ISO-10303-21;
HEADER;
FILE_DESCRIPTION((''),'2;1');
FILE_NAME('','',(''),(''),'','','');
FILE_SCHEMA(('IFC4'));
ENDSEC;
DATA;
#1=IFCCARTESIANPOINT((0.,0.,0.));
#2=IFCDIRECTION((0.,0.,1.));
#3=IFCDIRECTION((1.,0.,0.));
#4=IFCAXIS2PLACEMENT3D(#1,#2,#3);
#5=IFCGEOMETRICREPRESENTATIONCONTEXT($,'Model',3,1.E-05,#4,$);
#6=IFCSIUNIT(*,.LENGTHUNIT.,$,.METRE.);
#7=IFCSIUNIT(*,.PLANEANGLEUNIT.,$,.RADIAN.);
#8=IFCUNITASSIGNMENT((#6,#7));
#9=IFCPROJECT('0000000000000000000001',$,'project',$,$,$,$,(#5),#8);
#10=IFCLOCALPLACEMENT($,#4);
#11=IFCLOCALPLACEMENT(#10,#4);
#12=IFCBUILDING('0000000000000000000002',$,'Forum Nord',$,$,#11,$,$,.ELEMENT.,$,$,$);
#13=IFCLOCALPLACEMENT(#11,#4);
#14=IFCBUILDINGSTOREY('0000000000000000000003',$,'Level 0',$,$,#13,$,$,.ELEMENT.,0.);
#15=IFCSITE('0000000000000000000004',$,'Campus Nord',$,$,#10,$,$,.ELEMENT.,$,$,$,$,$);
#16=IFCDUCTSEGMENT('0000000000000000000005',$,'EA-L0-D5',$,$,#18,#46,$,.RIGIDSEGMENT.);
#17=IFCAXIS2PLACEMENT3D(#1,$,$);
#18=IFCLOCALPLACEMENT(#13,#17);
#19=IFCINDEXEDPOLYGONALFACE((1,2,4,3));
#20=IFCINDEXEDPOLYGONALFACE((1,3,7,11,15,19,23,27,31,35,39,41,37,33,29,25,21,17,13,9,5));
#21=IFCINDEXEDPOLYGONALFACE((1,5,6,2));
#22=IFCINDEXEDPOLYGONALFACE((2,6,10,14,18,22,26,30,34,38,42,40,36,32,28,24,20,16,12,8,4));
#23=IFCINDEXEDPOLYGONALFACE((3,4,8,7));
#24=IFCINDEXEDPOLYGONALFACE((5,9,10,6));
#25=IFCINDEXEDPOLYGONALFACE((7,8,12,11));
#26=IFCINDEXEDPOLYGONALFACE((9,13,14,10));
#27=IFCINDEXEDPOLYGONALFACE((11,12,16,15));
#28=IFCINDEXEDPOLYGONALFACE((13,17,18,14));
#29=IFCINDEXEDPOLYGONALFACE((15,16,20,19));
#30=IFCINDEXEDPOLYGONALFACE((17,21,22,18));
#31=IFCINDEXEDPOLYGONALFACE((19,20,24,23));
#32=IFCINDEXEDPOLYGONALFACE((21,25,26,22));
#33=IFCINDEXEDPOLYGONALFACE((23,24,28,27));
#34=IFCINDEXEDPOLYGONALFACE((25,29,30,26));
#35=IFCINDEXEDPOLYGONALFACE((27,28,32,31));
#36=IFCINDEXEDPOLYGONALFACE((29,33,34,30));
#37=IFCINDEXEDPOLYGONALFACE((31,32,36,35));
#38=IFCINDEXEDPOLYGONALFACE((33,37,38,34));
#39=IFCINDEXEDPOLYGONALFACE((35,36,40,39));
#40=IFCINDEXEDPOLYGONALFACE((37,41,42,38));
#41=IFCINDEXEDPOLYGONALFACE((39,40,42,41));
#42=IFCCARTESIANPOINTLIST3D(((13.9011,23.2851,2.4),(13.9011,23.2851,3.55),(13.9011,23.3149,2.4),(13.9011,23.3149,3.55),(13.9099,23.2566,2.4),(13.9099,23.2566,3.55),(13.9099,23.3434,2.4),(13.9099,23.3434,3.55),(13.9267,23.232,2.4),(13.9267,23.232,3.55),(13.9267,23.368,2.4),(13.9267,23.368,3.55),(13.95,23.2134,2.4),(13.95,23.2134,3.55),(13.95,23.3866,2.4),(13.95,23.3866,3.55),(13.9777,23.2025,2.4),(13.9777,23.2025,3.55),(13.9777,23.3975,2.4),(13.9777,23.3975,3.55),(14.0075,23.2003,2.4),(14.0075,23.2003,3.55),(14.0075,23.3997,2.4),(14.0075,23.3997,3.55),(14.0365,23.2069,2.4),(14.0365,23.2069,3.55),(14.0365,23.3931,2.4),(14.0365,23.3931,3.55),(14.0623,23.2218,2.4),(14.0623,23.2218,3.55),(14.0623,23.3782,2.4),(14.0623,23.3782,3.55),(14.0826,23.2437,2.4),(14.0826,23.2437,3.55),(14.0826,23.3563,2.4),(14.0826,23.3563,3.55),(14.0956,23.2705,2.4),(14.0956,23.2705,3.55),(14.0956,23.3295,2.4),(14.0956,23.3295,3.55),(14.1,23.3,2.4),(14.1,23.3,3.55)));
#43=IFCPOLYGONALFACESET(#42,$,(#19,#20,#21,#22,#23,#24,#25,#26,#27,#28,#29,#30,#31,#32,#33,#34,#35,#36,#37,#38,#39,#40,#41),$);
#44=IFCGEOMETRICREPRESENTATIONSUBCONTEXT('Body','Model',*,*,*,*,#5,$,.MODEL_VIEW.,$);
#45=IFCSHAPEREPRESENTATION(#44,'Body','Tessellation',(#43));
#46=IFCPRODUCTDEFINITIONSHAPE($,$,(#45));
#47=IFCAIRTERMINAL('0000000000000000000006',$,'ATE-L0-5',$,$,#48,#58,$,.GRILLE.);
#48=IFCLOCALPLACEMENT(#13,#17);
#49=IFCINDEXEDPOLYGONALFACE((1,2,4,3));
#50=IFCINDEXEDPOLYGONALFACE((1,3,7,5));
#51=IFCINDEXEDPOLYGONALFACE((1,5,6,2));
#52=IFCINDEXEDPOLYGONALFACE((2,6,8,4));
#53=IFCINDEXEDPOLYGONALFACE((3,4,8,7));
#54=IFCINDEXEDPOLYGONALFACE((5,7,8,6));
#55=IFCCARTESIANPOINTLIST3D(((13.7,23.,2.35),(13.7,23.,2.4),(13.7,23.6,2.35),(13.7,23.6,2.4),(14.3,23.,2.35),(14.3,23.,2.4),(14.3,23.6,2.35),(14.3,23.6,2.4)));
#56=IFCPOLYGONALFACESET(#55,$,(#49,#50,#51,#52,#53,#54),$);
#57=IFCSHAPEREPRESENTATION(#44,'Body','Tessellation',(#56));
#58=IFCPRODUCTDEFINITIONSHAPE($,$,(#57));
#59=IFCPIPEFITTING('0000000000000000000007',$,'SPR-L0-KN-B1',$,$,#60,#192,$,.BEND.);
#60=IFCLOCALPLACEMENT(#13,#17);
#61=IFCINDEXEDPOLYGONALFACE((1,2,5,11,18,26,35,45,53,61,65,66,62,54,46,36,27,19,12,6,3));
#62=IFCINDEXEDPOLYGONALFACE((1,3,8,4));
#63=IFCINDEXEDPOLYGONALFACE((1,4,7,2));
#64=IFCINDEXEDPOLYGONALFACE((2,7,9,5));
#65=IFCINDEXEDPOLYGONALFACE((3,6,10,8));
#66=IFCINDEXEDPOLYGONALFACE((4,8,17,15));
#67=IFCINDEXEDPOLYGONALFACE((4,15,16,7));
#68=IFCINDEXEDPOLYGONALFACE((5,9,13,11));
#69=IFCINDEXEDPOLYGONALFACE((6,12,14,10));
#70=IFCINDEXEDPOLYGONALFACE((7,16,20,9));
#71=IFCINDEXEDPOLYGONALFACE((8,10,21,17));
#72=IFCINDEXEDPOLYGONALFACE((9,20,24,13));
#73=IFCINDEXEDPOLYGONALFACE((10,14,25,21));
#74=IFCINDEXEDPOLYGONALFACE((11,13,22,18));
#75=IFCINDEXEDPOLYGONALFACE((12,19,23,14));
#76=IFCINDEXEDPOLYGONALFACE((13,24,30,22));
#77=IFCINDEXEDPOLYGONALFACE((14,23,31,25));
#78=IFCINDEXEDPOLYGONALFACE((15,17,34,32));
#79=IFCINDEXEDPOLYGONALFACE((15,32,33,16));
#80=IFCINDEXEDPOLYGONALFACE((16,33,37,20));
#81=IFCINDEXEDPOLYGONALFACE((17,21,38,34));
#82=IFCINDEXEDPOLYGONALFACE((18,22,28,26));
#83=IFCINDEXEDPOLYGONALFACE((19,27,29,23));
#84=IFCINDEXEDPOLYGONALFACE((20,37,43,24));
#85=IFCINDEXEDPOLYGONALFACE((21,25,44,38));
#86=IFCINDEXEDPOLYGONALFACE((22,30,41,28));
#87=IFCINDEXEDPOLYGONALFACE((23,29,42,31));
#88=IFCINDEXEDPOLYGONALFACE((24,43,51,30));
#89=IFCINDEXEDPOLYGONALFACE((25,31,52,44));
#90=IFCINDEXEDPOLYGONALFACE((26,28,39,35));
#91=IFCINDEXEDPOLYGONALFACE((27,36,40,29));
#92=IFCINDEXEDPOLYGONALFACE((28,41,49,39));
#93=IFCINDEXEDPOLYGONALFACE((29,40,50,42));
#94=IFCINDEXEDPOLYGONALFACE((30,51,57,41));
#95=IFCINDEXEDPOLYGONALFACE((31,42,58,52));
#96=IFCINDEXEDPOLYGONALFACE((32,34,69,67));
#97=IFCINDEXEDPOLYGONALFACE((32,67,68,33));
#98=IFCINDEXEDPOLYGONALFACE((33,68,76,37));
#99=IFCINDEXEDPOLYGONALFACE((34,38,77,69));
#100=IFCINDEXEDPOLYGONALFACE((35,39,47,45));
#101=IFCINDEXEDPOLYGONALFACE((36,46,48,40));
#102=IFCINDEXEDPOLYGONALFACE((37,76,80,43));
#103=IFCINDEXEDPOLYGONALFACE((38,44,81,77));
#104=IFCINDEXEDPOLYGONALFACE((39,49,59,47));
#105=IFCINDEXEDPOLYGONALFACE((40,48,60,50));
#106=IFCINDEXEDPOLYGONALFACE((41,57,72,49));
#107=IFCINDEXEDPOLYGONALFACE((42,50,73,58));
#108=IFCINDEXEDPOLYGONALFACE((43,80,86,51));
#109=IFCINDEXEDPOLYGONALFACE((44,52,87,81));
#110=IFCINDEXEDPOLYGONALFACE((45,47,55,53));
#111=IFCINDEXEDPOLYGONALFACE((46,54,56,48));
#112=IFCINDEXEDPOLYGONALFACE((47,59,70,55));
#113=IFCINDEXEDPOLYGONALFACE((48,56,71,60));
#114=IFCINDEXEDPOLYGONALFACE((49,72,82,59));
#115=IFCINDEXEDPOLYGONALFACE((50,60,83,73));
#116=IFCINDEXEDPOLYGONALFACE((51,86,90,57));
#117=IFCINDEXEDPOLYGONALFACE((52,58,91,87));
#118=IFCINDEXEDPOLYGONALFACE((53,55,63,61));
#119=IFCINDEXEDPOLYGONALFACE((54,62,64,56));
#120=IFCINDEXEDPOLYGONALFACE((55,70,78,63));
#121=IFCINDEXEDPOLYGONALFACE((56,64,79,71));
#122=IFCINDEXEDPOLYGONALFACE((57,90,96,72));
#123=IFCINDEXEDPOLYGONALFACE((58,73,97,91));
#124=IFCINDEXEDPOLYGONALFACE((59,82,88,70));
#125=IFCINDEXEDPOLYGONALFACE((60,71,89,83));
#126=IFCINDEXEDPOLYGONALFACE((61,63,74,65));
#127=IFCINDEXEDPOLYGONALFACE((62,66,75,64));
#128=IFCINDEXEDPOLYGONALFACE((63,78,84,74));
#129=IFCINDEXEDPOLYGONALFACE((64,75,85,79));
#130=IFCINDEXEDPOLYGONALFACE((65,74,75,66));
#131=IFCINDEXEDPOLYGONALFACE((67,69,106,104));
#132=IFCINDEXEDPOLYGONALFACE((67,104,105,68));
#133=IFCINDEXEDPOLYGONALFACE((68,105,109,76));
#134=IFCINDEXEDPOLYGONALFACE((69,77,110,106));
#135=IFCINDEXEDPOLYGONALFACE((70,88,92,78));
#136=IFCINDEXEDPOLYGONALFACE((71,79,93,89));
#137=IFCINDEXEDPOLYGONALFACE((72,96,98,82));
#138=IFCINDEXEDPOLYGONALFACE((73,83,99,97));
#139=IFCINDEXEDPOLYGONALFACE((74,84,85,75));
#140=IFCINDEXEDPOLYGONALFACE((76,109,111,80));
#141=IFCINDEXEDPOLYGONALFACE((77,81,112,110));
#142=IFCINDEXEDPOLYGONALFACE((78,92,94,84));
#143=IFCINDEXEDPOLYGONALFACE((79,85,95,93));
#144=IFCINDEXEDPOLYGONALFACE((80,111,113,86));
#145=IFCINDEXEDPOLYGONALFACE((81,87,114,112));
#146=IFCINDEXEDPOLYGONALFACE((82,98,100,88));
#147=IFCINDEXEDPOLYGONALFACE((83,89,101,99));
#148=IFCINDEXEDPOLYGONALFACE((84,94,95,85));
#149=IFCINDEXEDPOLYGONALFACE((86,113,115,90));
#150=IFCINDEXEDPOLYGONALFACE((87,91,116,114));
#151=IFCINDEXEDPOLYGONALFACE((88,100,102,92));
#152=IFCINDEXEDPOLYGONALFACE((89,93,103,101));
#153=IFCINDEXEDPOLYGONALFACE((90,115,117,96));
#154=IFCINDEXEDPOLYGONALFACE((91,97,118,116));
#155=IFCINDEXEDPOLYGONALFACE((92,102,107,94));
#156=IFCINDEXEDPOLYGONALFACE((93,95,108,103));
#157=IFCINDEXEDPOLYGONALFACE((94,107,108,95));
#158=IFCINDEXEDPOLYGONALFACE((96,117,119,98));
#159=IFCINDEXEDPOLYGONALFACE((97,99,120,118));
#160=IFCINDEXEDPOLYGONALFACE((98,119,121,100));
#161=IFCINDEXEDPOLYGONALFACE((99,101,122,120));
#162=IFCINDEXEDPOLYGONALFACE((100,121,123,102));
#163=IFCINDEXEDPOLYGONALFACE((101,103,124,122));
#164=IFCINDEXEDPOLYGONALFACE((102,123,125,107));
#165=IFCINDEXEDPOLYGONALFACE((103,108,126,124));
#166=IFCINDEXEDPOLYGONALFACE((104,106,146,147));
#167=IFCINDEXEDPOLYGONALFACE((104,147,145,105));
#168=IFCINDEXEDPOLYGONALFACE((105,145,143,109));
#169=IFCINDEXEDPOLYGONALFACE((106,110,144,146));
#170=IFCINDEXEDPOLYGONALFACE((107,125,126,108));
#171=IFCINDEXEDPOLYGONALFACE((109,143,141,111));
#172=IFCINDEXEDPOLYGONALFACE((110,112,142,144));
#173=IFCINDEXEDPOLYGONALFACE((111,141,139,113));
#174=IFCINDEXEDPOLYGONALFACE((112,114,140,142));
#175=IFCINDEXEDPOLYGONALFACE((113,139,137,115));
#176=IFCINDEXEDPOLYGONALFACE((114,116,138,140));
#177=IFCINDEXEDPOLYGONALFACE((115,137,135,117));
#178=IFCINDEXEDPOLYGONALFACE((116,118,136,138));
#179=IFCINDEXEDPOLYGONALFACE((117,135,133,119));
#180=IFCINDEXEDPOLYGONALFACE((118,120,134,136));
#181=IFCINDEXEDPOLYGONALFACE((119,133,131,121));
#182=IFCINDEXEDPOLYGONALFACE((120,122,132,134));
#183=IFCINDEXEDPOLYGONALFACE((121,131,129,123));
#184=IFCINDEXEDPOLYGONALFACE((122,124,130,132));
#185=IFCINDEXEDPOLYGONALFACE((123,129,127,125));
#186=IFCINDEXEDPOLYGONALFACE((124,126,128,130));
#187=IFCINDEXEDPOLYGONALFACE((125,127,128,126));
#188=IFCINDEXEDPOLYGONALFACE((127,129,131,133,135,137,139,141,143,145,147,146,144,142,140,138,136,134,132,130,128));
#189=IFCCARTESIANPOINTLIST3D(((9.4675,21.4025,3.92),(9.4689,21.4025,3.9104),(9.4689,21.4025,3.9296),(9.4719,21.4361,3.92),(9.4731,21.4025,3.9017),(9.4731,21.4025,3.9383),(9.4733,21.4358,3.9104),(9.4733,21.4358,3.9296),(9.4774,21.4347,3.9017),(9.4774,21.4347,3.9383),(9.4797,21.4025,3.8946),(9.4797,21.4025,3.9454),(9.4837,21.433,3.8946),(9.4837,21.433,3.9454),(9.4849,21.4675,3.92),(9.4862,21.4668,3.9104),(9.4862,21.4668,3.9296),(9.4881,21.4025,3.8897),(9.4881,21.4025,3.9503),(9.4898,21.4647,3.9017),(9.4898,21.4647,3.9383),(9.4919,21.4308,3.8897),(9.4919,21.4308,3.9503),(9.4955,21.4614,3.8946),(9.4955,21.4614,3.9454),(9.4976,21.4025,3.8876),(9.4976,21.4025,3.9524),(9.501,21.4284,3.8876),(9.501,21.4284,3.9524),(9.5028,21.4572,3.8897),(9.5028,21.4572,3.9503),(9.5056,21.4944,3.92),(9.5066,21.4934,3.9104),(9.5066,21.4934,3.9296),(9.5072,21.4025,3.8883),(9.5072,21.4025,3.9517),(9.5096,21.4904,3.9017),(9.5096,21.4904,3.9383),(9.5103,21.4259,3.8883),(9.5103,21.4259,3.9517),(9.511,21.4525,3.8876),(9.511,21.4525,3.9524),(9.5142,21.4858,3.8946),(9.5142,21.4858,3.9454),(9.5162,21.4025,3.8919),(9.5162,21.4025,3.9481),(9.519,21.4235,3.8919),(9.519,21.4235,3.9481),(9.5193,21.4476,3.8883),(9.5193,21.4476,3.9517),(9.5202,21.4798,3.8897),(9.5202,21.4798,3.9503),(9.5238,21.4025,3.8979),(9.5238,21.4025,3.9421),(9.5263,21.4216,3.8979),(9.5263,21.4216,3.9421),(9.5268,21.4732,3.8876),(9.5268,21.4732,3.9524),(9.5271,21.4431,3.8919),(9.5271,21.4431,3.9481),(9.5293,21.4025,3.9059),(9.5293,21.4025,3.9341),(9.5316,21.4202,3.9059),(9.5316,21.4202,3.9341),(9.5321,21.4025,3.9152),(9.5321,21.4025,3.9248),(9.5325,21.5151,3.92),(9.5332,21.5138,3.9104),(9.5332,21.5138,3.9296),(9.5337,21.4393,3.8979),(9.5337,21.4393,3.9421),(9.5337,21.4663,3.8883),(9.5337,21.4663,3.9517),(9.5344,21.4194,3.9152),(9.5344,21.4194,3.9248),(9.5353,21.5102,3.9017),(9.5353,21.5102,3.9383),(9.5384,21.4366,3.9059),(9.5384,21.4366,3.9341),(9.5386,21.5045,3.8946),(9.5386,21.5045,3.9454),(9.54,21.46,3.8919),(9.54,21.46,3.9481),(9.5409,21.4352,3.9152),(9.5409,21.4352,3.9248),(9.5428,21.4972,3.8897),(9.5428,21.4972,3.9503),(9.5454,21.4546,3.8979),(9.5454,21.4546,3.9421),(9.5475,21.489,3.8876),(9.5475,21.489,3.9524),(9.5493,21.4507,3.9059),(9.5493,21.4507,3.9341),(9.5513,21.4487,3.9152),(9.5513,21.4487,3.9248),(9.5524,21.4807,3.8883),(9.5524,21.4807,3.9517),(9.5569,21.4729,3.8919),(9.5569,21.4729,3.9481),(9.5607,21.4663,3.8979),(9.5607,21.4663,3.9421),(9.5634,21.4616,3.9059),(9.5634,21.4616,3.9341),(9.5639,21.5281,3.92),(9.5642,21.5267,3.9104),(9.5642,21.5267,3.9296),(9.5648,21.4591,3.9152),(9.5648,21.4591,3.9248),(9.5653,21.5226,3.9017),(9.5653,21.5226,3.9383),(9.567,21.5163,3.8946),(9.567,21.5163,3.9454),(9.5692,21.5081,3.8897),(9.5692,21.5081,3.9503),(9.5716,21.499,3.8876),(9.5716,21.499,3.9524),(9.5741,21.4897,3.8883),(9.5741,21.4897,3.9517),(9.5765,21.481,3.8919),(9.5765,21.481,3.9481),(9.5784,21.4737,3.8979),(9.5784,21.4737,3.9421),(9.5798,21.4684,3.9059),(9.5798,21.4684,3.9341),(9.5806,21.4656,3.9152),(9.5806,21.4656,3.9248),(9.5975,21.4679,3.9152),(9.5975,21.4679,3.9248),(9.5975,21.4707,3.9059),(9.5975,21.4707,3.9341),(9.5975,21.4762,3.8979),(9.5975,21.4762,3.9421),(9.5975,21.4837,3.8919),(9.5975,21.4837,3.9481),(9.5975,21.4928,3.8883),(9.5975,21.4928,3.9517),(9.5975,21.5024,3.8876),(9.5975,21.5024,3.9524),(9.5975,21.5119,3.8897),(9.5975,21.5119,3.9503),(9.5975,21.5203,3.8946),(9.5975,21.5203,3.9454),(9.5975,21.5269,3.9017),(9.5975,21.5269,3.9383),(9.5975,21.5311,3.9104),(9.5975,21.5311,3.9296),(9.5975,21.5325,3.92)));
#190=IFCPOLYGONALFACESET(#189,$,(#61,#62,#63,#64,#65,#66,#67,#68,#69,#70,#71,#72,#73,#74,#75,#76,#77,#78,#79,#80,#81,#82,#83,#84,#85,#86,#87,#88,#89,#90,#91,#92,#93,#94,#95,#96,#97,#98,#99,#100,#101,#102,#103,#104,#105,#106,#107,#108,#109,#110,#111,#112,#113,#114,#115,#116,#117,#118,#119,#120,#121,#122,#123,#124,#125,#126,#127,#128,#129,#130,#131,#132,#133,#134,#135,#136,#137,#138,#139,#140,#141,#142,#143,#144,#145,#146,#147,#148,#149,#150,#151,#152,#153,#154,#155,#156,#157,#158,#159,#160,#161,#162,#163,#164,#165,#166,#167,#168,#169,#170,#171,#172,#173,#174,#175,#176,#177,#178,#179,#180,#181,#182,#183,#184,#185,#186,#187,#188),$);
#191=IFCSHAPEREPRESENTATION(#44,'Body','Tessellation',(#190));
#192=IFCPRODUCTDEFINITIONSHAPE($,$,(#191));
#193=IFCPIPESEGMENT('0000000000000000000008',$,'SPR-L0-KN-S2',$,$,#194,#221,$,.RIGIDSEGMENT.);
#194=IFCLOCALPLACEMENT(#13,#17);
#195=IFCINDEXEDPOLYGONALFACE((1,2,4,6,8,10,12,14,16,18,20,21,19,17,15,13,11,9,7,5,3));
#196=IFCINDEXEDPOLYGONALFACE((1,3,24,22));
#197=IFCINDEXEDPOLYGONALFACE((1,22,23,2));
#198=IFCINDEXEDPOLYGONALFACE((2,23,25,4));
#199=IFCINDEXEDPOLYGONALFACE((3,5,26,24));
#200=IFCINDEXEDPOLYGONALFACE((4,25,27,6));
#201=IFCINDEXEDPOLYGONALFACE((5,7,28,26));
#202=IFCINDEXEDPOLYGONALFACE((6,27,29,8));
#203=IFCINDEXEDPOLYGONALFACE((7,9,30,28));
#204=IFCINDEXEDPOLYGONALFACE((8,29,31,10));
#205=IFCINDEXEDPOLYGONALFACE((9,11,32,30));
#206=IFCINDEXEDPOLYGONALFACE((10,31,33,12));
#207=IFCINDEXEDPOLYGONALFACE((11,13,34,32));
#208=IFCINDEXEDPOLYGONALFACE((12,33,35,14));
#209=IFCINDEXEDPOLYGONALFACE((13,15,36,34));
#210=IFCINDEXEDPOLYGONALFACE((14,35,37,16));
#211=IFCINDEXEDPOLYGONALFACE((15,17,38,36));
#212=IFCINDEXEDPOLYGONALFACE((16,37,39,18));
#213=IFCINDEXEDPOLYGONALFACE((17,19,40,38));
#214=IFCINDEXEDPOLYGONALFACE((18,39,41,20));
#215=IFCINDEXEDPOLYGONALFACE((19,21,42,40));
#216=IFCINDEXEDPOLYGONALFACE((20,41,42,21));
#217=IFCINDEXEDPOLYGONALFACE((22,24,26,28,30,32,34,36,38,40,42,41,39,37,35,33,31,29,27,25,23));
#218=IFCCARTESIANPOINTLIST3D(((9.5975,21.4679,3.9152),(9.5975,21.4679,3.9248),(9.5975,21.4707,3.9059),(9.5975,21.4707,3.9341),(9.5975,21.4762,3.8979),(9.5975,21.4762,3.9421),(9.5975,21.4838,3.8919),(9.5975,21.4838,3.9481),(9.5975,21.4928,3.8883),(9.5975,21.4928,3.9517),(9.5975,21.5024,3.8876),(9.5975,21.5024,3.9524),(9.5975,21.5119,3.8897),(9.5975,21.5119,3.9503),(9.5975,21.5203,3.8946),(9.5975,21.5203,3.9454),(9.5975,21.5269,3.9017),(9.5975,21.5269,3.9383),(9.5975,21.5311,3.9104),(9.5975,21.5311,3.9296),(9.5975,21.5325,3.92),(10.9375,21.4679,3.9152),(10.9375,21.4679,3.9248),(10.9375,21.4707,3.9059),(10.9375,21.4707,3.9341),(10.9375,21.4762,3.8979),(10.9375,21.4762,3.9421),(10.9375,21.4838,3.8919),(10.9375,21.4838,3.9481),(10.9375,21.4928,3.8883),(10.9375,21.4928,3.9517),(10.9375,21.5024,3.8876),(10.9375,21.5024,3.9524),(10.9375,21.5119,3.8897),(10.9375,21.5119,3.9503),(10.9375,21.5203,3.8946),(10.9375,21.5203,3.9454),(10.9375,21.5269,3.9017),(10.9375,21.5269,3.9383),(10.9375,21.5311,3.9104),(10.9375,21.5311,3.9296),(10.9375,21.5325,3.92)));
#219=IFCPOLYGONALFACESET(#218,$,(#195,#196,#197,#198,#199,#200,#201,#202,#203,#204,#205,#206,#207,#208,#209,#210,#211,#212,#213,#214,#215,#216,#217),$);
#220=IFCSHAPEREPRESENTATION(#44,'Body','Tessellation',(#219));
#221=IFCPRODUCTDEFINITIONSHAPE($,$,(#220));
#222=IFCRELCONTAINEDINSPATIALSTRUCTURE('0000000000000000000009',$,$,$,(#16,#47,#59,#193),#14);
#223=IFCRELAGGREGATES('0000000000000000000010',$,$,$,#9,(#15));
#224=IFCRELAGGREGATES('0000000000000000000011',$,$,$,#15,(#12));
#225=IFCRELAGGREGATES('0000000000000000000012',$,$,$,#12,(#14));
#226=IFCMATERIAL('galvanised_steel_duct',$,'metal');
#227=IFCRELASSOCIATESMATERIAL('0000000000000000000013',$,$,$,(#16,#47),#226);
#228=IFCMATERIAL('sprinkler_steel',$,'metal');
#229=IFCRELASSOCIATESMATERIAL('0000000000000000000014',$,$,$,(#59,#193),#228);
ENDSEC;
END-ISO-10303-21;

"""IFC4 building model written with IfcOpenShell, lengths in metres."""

from ifc_helpers import new_model, entity, si_unit, frame, origin_with_axes, origin_2d_with_axis, place, context, subcontext, project, spatial, rectangle, circle, extrude, material, element, save


model = new_model("IFC4")

# Units and contexts
model_context = context("Model", 3, precision=1e-05, world=origin_with_axes())
body_context = subcontext(model_context, "Body", "Model", "MODEL_VIEW")
ifc_project = project(units=[si_unit("LENGTHUNIT", "METRE"), si_unit("PLANEANGLEUNIT", "RADIAN")], contexts=[model_context])

# Site, building, storey
site_placement = place(None, origin_with_axes())
site = spatial("IfcSite", under=ifc_project, at=site_placement, Name="Campus Nord", CompositionType="ELEMENT")
building_placement = place(site_placement, origin_with_axes())
building = spatial("IfcBuilding", under=site, at=building_placement, Name="Forum Nord", CompositionType="ELEMENT")
storey_placement = place(building_placement, origin_with_axes())
storey = spatial("IfcBuildingStorey", under=building, at=storey_placement, Name="Level 0", CompositionType="ELEMENT", Elevation=0.0)

# Shared definitions
ifc_material_1 = material(Name="galvanised_steel_duct", Category="metal")

# Duct segment
duct_segment_1_placement = place(storey_placement, frame((14.0, 23.3, 3.55), z_axis=(0.0, 0.0, -1.0), x_axis=(1.0, 0.0, 0.0)))
element("IfcDuctSegment", 1, at=duct_segment_1_placement, inside=storey, material=ifc_material_1, Name="EA-L0-D5", PredefinedType="RIGIDSEGMENT", context=body_context, shape_type="SweptSolid", body=[
    extrude(circle(Radius=0.1, at=origin_2d_with_axis()), origin_with_axes(), (0.0, 0.0, 1.0), 1.15),
])

# Air terminal
air_terminal_1_placement = place(storey_placement, frame((14.0, 23.3, 2.35), z_axis=(0.0, 0.0, 1.0), x_axis=(1.0, 0.0, 0.0)))
element("IfcAirTerminal", 2, at=air_terminal_1_placement, inside=storey, material=ifc_material_1, Name="ATE-L0-5", PredefinedType="GRILLE", context=body_context, shape_type="SweptSolid", body=[
    extrude(rectangle(XDim=0.6, YDim=0.6, at=origin_2d_with_axis()), origin_with_axes(), (0.0, 0.0, 1.0), 0.05),
])

# Pipe fitting
ifc_material_2 = material(Name="sprinkler_steel", Category="metal")
pipe_fitting_1_placement = place(storey_placement, frame((9.5, 21.4025, 3.92), z_axis=(0.0, 1.0, 0.0), x_axis=(-1.0, 0.0, 0.0)))
element("IfcPipeFitting", 3, at=pipe_fitting_1_placement, inside=storey, material=ifc_material_2, Name="SPR-L0-KN-B1", PredefinedType="BEND", context=body_context, shape_type="SweptSolid", body=[
    entity("IfcRevolvedAreaSolid", entity("IfcCircleProfileDef", "AREA", None, entity("IfcAxis2Placement2D", entity("IfcCartesianPoint", [0.0, 0.0]), entity("IfcDirection", [1.0, 0.0])), 0.0325), entity("IfcAxis2Placement3D", entity("IfcCartesianPoint", [0.0, 0.0, 0.0]), entity("IfcDirection", [0.0, 0.0, 1.0]), entity("IfcDirection", [1.0, 0.0, 0.0])), entity("IfcAxis1Placement", entity("IfcCartesianPoint", [-0.0975, 0.0, 0.0]), entity("IfcDirection", [0.0, -1.0, 0.0])), 1.5708),
])

# Pipe segment
pipe_segment_1_placement = place(storey_placement, frame((9.5975, 21.5, 3.92), z_axis=(1.0, 0.0, 0.0), x_axis=(0.0, 1.0, 0.0)))
element("IfcPipeSegment", 4, at=pipe_segment_1_placement, inside=storey, material=ifc_material_2, Name="SPR-L0-KN-S2", PredefinedType="RIGIDSEGMENT", context=body_context, shape_type="SweptSolid", body=[
    extrude(circle(Radius=0.0325, at=origin_2d_with_axis()), origin_with_axes(), (0.0, 0.0, 1.0), 1.34),
])

save(model, "model.ifc")
